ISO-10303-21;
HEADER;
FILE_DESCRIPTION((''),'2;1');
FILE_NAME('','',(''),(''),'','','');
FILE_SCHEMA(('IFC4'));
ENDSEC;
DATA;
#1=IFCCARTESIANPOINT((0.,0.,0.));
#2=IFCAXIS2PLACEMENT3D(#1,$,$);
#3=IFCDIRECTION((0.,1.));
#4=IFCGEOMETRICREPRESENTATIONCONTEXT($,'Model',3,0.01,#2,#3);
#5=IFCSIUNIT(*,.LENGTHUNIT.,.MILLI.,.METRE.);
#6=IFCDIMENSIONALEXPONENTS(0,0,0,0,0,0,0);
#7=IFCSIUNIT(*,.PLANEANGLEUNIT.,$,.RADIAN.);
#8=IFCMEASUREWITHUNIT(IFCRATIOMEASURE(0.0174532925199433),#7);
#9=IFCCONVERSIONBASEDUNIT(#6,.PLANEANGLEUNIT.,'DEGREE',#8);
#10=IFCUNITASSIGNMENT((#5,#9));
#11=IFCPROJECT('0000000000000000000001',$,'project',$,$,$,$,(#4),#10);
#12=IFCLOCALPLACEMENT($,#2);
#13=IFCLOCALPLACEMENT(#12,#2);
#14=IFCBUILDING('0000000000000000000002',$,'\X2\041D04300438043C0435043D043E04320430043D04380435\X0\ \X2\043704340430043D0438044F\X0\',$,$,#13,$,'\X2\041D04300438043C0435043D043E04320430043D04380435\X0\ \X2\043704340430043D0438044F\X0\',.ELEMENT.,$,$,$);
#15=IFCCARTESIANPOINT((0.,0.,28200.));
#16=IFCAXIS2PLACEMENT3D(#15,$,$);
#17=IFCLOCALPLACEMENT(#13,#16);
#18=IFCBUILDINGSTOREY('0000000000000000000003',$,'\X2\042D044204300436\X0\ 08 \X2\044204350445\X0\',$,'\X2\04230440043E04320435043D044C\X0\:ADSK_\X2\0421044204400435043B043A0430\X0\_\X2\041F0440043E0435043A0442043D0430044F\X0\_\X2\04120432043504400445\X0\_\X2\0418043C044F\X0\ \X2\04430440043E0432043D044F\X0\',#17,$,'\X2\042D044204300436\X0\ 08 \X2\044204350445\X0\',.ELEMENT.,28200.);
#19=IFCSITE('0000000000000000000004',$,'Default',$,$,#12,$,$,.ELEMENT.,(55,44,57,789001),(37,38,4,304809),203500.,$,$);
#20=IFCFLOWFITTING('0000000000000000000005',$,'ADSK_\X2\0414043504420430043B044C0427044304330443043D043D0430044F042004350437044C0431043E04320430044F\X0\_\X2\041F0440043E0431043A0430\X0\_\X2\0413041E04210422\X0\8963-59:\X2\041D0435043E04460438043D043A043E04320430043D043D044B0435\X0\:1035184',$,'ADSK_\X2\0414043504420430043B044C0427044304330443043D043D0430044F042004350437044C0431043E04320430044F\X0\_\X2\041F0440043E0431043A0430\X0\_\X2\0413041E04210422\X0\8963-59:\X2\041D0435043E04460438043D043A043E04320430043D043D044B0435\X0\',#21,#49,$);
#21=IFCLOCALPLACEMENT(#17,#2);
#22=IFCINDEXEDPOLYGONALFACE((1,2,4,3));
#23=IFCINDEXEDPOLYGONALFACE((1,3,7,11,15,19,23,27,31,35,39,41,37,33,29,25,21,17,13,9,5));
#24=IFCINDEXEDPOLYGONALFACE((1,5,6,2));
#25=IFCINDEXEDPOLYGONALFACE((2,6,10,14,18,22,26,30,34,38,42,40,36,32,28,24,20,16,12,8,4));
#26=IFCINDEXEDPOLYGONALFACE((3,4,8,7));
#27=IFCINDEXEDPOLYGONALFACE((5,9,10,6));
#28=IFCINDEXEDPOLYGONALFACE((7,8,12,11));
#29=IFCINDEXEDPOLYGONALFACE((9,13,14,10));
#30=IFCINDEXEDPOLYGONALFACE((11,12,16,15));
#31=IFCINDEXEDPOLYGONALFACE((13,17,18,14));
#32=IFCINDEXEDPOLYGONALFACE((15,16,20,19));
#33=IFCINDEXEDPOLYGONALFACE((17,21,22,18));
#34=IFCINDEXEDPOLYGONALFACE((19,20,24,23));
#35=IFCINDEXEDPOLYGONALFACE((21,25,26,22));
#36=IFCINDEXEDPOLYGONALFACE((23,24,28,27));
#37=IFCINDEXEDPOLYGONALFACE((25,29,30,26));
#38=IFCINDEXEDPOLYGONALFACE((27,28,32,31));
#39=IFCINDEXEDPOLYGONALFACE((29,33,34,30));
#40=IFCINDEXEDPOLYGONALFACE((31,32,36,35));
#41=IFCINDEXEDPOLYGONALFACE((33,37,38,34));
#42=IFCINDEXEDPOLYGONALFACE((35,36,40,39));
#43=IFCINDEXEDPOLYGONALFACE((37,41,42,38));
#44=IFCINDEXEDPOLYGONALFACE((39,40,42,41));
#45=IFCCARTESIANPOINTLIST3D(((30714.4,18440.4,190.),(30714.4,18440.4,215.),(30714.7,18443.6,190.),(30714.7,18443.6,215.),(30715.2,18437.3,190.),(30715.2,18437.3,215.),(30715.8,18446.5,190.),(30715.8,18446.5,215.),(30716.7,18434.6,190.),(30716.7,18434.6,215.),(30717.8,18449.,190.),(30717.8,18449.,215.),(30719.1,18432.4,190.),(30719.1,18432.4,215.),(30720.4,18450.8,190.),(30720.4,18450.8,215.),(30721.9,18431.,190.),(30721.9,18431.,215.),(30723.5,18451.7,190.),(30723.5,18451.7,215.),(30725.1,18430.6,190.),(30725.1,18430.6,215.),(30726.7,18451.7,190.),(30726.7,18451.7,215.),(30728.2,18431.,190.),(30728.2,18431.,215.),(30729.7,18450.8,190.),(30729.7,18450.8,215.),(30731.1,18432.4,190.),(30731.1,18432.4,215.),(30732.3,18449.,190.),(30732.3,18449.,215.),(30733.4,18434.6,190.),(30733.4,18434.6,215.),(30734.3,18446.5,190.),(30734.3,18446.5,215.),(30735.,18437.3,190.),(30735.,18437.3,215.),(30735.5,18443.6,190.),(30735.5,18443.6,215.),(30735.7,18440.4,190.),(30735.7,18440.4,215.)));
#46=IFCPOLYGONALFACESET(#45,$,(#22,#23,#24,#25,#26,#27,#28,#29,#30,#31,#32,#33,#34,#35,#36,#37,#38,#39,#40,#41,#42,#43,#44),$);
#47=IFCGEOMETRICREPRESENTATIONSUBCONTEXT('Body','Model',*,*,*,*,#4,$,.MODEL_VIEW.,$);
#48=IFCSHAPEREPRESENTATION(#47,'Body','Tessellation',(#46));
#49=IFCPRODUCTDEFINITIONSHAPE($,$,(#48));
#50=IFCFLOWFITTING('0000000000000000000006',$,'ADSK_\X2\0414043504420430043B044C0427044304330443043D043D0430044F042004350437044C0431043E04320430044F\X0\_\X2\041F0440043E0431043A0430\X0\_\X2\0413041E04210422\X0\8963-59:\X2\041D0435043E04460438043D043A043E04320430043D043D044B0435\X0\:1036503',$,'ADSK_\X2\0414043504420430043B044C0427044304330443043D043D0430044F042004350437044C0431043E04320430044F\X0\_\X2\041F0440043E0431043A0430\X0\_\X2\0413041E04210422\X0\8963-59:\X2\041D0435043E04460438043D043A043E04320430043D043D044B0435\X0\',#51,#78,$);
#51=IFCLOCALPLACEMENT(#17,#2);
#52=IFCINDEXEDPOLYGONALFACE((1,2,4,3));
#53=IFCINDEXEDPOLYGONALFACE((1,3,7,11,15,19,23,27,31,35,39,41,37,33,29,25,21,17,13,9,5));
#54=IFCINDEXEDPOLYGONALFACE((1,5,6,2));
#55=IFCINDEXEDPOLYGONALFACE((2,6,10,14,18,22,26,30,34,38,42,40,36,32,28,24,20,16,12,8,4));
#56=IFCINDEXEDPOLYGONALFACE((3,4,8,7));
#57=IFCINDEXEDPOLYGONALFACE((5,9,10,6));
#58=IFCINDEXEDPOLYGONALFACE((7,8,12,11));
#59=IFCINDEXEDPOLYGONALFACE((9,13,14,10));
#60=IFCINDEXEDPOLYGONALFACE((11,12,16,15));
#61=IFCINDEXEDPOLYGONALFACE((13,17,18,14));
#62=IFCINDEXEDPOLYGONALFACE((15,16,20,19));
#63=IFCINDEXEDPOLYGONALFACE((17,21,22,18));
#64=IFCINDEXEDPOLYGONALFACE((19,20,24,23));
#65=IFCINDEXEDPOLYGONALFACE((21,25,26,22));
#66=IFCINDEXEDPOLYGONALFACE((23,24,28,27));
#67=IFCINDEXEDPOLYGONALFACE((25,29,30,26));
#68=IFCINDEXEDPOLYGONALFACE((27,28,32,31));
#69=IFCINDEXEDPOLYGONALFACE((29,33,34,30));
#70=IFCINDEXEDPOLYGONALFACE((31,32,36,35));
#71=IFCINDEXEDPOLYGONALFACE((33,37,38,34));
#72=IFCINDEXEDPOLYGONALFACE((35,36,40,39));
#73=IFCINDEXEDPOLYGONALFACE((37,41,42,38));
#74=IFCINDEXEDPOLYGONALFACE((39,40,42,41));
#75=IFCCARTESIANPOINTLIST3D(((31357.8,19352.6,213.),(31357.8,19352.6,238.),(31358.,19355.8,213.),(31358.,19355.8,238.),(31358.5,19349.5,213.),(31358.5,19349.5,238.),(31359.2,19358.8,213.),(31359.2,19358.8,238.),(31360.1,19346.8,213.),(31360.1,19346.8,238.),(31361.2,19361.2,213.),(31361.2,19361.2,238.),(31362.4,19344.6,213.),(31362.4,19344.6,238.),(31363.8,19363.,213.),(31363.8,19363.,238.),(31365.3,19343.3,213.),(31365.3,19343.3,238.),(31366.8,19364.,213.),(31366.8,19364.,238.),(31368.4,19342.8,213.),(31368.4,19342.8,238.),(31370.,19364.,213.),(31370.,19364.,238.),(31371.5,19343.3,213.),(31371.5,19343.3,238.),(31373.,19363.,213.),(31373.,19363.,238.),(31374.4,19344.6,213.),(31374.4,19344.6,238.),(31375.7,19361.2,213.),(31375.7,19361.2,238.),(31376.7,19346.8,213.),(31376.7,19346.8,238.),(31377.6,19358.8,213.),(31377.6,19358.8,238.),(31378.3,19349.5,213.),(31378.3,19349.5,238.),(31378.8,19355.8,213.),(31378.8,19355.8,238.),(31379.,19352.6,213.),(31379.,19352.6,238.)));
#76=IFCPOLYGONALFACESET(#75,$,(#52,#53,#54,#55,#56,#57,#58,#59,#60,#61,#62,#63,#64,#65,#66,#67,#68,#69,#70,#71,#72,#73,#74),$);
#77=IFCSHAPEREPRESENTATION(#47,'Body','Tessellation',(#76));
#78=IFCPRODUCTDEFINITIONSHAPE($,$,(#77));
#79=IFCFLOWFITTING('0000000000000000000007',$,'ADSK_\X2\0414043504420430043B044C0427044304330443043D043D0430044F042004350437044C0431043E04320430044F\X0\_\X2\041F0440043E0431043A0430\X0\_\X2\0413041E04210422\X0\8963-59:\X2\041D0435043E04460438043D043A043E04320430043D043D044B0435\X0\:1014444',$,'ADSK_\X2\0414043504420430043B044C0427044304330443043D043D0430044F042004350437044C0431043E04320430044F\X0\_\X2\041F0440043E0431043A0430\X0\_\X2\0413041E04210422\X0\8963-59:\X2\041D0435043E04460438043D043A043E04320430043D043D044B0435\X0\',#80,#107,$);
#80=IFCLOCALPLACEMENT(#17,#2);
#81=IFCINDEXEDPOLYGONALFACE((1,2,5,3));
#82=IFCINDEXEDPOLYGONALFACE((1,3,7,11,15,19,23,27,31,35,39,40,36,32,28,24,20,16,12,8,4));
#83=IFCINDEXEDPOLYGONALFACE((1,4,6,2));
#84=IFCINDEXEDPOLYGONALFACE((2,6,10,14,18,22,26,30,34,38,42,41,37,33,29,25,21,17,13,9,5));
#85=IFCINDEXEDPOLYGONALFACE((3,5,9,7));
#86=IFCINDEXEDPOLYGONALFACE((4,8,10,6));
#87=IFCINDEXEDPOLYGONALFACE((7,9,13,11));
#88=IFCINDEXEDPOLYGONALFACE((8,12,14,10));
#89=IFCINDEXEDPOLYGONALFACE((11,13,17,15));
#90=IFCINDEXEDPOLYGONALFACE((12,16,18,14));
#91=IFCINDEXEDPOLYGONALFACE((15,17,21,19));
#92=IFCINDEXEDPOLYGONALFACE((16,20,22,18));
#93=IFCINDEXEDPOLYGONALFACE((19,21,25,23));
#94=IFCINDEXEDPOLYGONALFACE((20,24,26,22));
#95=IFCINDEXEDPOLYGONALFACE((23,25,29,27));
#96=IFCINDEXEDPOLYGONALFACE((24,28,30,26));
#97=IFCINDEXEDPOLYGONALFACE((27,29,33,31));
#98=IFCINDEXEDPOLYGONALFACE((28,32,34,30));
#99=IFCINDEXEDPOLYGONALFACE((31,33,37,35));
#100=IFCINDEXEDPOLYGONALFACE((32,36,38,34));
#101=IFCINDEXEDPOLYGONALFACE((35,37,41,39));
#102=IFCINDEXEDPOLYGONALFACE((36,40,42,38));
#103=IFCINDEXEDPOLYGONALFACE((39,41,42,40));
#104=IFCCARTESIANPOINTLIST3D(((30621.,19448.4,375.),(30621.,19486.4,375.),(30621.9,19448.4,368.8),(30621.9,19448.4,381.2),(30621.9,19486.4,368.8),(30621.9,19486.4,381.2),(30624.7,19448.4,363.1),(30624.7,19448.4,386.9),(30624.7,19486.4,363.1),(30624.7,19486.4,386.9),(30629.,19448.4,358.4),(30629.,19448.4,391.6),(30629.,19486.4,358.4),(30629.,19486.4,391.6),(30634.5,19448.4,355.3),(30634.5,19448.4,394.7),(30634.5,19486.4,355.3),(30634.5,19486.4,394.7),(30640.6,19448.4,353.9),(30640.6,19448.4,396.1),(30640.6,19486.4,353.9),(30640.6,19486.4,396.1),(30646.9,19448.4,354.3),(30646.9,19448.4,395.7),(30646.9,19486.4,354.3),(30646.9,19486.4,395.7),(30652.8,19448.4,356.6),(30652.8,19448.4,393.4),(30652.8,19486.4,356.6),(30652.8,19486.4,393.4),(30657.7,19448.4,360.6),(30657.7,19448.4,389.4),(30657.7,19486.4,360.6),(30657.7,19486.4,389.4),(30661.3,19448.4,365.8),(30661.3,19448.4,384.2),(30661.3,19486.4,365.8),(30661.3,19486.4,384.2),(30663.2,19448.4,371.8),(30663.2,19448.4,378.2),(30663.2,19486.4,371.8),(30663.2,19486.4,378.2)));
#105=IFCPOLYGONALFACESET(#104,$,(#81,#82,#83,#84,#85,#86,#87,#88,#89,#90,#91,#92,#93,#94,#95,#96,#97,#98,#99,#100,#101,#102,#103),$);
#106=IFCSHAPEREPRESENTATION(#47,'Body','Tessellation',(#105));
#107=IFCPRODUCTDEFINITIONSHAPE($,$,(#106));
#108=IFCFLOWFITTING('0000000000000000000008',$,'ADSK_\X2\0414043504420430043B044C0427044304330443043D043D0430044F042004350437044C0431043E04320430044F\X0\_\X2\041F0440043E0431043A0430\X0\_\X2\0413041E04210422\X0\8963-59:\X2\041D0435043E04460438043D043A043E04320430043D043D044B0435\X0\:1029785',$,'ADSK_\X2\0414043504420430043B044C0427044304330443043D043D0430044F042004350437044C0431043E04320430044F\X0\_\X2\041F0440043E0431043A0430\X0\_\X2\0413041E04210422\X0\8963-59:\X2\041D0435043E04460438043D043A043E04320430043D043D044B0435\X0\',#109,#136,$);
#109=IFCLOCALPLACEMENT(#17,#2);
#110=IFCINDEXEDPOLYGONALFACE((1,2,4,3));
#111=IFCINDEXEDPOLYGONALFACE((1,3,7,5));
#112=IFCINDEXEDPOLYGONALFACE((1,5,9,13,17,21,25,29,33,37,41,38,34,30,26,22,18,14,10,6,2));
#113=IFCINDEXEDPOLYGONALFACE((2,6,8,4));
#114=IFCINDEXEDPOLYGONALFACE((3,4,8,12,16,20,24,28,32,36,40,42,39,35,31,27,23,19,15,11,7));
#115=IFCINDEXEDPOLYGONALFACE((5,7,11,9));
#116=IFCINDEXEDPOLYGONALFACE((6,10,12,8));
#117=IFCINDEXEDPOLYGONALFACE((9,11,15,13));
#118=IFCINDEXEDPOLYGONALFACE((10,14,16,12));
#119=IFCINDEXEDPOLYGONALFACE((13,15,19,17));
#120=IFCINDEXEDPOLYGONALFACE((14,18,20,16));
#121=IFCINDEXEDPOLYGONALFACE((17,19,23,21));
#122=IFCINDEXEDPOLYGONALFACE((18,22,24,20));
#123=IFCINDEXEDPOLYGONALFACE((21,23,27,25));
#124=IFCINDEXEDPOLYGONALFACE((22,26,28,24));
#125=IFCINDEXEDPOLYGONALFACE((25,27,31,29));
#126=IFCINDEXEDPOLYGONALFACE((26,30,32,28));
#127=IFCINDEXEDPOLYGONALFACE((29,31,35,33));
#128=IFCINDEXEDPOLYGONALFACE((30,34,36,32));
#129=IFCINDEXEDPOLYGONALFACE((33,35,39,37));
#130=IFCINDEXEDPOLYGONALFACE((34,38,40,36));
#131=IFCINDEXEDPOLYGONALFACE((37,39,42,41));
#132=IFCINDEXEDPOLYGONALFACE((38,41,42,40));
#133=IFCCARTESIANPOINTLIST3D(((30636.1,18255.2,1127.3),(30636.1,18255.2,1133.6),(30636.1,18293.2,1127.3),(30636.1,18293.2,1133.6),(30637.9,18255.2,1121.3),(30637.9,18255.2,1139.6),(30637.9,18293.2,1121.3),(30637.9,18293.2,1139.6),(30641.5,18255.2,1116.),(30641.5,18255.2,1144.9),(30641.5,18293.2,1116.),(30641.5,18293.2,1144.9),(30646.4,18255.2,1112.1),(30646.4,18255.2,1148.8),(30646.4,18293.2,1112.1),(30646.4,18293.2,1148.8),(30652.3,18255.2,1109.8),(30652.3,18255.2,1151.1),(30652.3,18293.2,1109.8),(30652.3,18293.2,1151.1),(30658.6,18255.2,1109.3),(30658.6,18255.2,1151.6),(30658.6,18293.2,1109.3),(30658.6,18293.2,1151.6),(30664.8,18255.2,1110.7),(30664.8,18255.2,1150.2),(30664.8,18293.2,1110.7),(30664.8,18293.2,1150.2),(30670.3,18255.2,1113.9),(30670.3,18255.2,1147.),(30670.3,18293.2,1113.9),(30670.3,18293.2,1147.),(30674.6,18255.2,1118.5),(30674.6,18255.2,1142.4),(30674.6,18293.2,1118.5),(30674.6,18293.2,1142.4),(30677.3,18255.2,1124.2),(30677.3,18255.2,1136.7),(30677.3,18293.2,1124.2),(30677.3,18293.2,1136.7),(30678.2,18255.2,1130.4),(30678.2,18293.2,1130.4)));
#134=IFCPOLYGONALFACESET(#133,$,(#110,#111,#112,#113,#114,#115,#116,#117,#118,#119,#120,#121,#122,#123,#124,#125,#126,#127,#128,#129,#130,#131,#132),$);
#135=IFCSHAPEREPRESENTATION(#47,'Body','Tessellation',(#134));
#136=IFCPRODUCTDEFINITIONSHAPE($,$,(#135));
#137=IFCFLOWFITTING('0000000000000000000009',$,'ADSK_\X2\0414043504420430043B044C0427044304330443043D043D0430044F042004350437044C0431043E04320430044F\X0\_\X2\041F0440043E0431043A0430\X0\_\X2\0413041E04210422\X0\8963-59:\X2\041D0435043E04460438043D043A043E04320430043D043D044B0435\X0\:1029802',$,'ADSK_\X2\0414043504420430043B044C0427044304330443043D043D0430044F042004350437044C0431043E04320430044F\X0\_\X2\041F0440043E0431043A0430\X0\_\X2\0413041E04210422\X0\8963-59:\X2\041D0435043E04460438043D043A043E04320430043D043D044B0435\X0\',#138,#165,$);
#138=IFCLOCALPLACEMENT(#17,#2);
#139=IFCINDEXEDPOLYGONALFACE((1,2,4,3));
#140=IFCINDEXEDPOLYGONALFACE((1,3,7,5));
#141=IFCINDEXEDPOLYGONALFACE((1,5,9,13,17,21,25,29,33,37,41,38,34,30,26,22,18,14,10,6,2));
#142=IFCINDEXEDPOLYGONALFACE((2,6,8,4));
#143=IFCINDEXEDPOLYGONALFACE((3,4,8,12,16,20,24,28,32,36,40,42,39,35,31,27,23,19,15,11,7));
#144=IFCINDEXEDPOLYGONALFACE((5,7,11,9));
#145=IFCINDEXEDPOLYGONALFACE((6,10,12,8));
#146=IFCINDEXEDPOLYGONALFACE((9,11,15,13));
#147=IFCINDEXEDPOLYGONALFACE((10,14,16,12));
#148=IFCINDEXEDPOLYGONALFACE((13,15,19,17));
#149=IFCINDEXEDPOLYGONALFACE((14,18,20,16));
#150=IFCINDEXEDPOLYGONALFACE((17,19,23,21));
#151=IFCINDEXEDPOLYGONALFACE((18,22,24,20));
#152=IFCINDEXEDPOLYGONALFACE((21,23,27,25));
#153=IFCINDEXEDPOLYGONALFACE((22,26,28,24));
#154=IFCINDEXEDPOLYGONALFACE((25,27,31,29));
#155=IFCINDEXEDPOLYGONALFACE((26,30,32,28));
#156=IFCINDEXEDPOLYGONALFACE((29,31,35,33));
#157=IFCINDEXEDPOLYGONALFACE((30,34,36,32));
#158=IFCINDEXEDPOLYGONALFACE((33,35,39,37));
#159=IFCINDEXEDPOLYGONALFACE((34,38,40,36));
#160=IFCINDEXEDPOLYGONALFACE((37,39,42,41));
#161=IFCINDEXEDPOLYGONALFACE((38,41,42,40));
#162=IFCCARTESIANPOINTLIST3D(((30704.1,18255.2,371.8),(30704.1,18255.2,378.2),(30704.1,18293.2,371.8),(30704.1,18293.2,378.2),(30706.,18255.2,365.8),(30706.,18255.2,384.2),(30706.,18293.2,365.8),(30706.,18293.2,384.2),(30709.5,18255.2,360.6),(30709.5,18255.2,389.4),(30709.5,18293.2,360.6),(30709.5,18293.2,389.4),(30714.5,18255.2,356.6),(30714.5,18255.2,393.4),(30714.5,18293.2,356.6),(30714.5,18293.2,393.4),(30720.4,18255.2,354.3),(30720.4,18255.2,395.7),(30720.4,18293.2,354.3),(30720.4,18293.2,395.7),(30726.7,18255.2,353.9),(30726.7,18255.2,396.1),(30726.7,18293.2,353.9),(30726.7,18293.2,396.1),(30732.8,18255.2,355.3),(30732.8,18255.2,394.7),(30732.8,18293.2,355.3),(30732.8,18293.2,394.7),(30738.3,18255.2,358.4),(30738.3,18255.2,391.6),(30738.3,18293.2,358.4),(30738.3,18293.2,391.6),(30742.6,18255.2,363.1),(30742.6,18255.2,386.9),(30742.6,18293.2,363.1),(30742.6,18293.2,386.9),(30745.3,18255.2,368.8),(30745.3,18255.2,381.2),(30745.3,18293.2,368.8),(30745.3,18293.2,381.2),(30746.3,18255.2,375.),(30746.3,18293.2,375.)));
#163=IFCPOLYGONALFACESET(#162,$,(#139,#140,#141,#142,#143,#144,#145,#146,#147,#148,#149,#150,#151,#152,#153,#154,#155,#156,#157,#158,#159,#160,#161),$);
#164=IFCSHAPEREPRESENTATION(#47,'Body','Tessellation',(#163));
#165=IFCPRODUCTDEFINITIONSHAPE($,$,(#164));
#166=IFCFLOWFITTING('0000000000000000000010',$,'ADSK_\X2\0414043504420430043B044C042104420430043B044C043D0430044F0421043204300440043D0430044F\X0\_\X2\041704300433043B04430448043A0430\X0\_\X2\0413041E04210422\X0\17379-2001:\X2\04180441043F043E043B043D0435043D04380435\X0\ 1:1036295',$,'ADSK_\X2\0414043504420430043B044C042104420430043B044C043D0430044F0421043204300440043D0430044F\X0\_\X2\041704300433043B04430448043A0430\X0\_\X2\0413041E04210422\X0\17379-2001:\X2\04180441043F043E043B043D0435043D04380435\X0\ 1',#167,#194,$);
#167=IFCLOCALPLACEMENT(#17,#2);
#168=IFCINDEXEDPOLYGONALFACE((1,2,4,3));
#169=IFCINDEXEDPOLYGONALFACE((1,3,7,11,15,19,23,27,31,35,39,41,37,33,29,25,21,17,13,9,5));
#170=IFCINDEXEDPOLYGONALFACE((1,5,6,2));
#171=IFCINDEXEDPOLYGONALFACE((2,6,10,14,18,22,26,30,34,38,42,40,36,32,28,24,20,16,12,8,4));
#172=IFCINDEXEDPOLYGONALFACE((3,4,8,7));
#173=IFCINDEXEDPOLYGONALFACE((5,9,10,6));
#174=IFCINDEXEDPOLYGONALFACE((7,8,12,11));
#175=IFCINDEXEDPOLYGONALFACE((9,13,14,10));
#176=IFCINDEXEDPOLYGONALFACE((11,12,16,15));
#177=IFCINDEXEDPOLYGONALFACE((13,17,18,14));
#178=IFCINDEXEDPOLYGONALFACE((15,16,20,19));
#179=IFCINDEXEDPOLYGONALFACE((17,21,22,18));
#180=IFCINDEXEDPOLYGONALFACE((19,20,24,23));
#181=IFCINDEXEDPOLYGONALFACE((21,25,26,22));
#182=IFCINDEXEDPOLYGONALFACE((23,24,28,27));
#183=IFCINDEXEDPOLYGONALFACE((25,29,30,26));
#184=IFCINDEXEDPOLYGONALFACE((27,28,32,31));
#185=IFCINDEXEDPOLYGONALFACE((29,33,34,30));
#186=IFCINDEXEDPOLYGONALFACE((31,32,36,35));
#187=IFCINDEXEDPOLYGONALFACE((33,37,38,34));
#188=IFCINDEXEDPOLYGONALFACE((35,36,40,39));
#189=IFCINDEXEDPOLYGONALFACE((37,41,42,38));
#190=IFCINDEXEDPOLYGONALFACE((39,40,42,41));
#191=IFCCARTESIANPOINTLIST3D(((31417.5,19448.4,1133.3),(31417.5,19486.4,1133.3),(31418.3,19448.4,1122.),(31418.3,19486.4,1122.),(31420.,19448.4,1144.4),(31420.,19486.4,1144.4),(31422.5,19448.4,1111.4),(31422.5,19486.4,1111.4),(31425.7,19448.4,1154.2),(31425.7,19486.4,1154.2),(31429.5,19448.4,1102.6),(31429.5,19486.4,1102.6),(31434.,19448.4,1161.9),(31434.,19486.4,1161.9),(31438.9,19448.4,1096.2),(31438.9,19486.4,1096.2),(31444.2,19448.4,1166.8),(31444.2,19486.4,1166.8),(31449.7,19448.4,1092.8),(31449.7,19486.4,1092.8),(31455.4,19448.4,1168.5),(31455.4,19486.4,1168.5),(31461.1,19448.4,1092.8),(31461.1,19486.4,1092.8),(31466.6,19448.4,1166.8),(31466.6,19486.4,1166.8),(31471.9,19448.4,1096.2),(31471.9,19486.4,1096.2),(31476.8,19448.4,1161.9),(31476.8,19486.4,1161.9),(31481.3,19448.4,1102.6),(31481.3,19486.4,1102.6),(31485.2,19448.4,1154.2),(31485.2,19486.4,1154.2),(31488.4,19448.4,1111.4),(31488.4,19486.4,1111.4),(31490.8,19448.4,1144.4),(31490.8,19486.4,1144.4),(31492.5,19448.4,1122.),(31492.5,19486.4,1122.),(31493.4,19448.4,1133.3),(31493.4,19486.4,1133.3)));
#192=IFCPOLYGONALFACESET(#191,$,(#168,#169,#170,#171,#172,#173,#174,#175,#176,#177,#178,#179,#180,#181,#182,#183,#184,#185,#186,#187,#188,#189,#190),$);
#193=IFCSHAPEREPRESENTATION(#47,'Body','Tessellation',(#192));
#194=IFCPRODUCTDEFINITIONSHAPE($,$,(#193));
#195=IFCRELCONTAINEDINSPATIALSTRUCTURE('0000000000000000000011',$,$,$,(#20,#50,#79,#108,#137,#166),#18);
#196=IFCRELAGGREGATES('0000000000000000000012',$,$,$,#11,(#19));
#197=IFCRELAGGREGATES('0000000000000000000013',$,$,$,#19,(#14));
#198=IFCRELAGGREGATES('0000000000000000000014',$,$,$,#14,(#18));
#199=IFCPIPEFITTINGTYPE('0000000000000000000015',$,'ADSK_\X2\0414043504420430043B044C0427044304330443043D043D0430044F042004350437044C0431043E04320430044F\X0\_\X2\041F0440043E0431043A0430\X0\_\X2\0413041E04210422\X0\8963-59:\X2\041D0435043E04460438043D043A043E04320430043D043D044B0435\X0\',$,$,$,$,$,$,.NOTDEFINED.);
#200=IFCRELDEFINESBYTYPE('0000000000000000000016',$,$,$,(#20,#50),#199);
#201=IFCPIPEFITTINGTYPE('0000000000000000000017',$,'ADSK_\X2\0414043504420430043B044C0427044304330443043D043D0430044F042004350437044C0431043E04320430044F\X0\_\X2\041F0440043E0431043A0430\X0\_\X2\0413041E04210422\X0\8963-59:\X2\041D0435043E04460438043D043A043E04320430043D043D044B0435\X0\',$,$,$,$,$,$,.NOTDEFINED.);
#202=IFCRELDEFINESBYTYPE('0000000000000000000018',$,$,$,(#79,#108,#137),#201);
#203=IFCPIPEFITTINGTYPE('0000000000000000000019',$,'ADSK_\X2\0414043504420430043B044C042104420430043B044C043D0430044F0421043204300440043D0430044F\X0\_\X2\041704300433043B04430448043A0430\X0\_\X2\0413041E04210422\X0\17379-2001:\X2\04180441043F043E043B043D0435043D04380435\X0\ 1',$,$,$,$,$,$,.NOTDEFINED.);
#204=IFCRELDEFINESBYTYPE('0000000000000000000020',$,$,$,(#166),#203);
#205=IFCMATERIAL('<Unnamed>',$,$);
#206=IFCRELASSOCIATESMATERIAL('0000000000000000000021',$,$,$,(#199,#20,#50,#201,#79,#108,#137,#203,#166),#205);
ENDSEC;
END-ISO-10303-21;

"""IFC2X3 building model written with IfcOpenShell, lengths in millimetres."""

from ifc_helpers import new_model, entity, si_unit, converted_unit, direction, frame, origin, origin_2d_with_axis, place, context, subcontext, project, spatial, circle, extrude, source, transform, mapped, material, type_object, type_shapes, element, save


model = new_model("IFC2X3")

# Units and contexts
model_context = context("Model", 3, precision=0.01, world=origin(), true_north=direction((0.0, 1.0)))
body_context = subcontext(model_context, "Body", "Model", "MODEL_VIEW")
ifc_project = project(units=[si_unit("LENGTHUNIT", "METRE", prefix="MILLI"), converted_unit("PLANEANGLEUNIT", "DEGREE", entity("IfcRatioMeasure", 0.0174532925199433), si_unit("PLANEANGLEUNIT", "RADIAN"), dimensions=[0, 0, 0, 0, 0, 0, 0])], contexts=[model_context])

# Site, building, storey
site_placement = place(None, origin())
site = spatial("IfcSite", under=ifc_project, at=site_placement, Name="Default", CompositionType="ELEMENT", RefLatitude=(55, 44, 57, 789001), RefLongitude=(37, 38, 4, 304809), RefElevation=203500.0)
building_placement = place(site_placement, origin())
building = spatial("IfcBuilding", under=site, at=building_placement, Name="Наименование здания", LongName="Наименование здания", CompositionType="ELEMENT")
storey_placement = place(building_placement, frame((0.0, 0.0, 28200.0)))
storey = spatial("IfcBuildingStorey", under=building, at=storey_placement, Name="Этаж 08 тех", ObjectType="Уровень:ADSK_Стрелка_Проектная_Вверх_Имя уровня", LongName="Этаж 08 тех", CompositionType="ELEMENT", Elevation=28200.0)

# Shared definitions
ifc_material = material(Name="<Unnamed>")

# Flow fittings
pipe_fitting_type_1 = type_object("IfcPipeFittingType", Name="ADSK_ДетальЧугуннаяРезьбовая_Пробка_ГОСТ8963-59:Неоцинкованные", PredefinedType="NOTDEFINED", material=ifc_material)
shared_shape_1 = source(origin(), body_context, "Body", "SweptSolid", [
    extrude(circle(Radius=10.7, at=origin_2d_with_axis()), frame((0.0, 0.0, 0.0), z_axis=(1.0, 0.0, 0.0), x_axis=(0.0, 1.0, 0.0)), (0.0, 0.0, 1.0), 25.0),
])
type_shapes(pipe_fitting_type_1, [shared_shape_1])
for number, where, z_axis, x_axis, name in (
    (1, (30725.1, 18441.2, 215.0), (-1.0, 0.0, 0.0), (0.0, 0.0, -1.0), "ADSK_ДетальЧугуннаяРезьбовая_Пробка_ГОСТ8963-59:Неоцинкованные:1035184"),
    (2, (31368.4, 19353.4, 238.0), (-1.0, 0.0, 0.0), (0.0, 0.0, -1.0), "ADSK_ДетальЧугуннаяРезьбовая_Пробка_ГОСТ8963-59:Неоцинкованные:1036503"),
):
    element("IfcFlowFitting", number, at=place(storey_placement, frame(where, z_axis=z_axis, x_axis=x_axis)), inside=storey, type_object=pipe_fitting_type_1, material=ifc_material, Name=name, ObjectType="ADSK_ДетальЧугуннаяРезьбовая_Пробка_ГОСТ8963-59:Неоцинкованные", context=body_context, shape_type="MappedRepresentation", body=[
        mapped(shared_shape_1, transform((0.0, 0.0, 0.0), scale=1.0)),
    ])
pipe_fitting_type_2 = type_object("IfcPipeFittingType", Name="ADSK_ДетальЧугуннаяРезьбовая_Пробка_ГОСТ8963-59:Неоцинкованные", PredefinedType="NOTDEFINED", material=ifc_material)
shared_shape_2 = source(origin(), body_context, "Body", "SweptSolid", [
    extrude(circle(Radius=21.2, at=origin_2d_with_axis()), frame((0.0, 0.0, 0.0), z_axis=(1.0, 0.0, 0.0), x_axis=(0.0, 1.0, 0.0)), (0.0, 0.0, 1.0), 38.0),
])
type_shapes(pipe_fitting_type_2, [shared_shape_2])
for number, where, z_axis, x_axis, name in (
    (3, (30642.2, 19448.4, 375.0), (0.0, 0.0, 1.0), (0.0, 1.0, 0.0), "ADSK_ДетальЧугуннаяРезьбовая_Пробка_ГОСТ8963-59:Неоцинкованные:1014444"),
    (4, (30657.0, 18293.2, 1130.5), (0.0, 0.0, 1.0), (0.0, -1.0, 0.0), "ADSK_ДетальЧугуннаяРезьбовая_Пробка_ГОСТ8963-59:Неоцинкованные:1029785"),
    (5, (30725.1, 18293.2, 375.0), (0.0, 0.0, 1.0), (0.0, -1.0, 0.0), "ADSK_ДетальЧугуннаяРезьбовая_Пробка_ГОСТ8963-59:Неоцинкованные:1029802"),
):
    element("IfcFlowFitting", number, at=place(storey_placement, frame(where, z_axis=z_axis, x_axis=x_axis)), inside=storey, type_object=pipe_fitting_type_2, material=ifc_material, Name=name, ObjectType="ADSK_ДетальЧугуннаяРезьбовая_Пробка_ГОСТ8963-59:Неоцинкованные", context=body_context, shape_type="MappedRepresentation", body=[
        mapped(shared_shape_2, transform((0.0, 0.0, 0.0), scale=1.0)),
    ])
pipe_fitting_type_3 = type_object("IfcPipeFittingType", Name="ADSK_ДетальСтальнаяСварная_Заглушка_ГОСТ17379-2001:Исполнение 1", PredefinedType="NOTDEFINED", material=ifc_material)
shared_shape_3 = source(origin(), body_context, "Body", "SweptSolid", [
    extrude(circle(Radius=38.0, at=origin_2d_with_axis()), frame((0.0, 0.0, 0.0), z_axis=(1.0, 0.0, 0.0), x_axis=(0.0, 1.0, 0.0)), (0.0, 0.0, 1.0), 38.0),
])
type_shapes(pipe_fitting_type_3, [shared_shape_3])
for number, where, z_axis, x_axis, name in (
    (6, (31455.4, 19448.4, 1130.5), (1.0, 0.0, 0.0), (0.0, 1.0, 0.0), "ADSK_ДетальСтальнаяСварная_Заглушка_ГОСТ17379-2001:Исполнение 1:1036295"),
):
    element("IfcFlowFitting", number, at=place(storey_placement, frame(where, z_axis=z_axis, x_axis=x_axis)), inside=storey, type_object=pipe_fitting_type_3, material=ifc_material, Name=name, ObjectType="ADSK_ДетальСтальнаяСварная_Заглушка_ГОСТ17379-2001:Исполнение 1", context=body_context, shape_type="MappedRepresentation", body=[
        mapped(shared_shape_3, transform((0.0, 0.0, 0.0), scale=1.0)),
    ])

save(model, "model.ifc")
